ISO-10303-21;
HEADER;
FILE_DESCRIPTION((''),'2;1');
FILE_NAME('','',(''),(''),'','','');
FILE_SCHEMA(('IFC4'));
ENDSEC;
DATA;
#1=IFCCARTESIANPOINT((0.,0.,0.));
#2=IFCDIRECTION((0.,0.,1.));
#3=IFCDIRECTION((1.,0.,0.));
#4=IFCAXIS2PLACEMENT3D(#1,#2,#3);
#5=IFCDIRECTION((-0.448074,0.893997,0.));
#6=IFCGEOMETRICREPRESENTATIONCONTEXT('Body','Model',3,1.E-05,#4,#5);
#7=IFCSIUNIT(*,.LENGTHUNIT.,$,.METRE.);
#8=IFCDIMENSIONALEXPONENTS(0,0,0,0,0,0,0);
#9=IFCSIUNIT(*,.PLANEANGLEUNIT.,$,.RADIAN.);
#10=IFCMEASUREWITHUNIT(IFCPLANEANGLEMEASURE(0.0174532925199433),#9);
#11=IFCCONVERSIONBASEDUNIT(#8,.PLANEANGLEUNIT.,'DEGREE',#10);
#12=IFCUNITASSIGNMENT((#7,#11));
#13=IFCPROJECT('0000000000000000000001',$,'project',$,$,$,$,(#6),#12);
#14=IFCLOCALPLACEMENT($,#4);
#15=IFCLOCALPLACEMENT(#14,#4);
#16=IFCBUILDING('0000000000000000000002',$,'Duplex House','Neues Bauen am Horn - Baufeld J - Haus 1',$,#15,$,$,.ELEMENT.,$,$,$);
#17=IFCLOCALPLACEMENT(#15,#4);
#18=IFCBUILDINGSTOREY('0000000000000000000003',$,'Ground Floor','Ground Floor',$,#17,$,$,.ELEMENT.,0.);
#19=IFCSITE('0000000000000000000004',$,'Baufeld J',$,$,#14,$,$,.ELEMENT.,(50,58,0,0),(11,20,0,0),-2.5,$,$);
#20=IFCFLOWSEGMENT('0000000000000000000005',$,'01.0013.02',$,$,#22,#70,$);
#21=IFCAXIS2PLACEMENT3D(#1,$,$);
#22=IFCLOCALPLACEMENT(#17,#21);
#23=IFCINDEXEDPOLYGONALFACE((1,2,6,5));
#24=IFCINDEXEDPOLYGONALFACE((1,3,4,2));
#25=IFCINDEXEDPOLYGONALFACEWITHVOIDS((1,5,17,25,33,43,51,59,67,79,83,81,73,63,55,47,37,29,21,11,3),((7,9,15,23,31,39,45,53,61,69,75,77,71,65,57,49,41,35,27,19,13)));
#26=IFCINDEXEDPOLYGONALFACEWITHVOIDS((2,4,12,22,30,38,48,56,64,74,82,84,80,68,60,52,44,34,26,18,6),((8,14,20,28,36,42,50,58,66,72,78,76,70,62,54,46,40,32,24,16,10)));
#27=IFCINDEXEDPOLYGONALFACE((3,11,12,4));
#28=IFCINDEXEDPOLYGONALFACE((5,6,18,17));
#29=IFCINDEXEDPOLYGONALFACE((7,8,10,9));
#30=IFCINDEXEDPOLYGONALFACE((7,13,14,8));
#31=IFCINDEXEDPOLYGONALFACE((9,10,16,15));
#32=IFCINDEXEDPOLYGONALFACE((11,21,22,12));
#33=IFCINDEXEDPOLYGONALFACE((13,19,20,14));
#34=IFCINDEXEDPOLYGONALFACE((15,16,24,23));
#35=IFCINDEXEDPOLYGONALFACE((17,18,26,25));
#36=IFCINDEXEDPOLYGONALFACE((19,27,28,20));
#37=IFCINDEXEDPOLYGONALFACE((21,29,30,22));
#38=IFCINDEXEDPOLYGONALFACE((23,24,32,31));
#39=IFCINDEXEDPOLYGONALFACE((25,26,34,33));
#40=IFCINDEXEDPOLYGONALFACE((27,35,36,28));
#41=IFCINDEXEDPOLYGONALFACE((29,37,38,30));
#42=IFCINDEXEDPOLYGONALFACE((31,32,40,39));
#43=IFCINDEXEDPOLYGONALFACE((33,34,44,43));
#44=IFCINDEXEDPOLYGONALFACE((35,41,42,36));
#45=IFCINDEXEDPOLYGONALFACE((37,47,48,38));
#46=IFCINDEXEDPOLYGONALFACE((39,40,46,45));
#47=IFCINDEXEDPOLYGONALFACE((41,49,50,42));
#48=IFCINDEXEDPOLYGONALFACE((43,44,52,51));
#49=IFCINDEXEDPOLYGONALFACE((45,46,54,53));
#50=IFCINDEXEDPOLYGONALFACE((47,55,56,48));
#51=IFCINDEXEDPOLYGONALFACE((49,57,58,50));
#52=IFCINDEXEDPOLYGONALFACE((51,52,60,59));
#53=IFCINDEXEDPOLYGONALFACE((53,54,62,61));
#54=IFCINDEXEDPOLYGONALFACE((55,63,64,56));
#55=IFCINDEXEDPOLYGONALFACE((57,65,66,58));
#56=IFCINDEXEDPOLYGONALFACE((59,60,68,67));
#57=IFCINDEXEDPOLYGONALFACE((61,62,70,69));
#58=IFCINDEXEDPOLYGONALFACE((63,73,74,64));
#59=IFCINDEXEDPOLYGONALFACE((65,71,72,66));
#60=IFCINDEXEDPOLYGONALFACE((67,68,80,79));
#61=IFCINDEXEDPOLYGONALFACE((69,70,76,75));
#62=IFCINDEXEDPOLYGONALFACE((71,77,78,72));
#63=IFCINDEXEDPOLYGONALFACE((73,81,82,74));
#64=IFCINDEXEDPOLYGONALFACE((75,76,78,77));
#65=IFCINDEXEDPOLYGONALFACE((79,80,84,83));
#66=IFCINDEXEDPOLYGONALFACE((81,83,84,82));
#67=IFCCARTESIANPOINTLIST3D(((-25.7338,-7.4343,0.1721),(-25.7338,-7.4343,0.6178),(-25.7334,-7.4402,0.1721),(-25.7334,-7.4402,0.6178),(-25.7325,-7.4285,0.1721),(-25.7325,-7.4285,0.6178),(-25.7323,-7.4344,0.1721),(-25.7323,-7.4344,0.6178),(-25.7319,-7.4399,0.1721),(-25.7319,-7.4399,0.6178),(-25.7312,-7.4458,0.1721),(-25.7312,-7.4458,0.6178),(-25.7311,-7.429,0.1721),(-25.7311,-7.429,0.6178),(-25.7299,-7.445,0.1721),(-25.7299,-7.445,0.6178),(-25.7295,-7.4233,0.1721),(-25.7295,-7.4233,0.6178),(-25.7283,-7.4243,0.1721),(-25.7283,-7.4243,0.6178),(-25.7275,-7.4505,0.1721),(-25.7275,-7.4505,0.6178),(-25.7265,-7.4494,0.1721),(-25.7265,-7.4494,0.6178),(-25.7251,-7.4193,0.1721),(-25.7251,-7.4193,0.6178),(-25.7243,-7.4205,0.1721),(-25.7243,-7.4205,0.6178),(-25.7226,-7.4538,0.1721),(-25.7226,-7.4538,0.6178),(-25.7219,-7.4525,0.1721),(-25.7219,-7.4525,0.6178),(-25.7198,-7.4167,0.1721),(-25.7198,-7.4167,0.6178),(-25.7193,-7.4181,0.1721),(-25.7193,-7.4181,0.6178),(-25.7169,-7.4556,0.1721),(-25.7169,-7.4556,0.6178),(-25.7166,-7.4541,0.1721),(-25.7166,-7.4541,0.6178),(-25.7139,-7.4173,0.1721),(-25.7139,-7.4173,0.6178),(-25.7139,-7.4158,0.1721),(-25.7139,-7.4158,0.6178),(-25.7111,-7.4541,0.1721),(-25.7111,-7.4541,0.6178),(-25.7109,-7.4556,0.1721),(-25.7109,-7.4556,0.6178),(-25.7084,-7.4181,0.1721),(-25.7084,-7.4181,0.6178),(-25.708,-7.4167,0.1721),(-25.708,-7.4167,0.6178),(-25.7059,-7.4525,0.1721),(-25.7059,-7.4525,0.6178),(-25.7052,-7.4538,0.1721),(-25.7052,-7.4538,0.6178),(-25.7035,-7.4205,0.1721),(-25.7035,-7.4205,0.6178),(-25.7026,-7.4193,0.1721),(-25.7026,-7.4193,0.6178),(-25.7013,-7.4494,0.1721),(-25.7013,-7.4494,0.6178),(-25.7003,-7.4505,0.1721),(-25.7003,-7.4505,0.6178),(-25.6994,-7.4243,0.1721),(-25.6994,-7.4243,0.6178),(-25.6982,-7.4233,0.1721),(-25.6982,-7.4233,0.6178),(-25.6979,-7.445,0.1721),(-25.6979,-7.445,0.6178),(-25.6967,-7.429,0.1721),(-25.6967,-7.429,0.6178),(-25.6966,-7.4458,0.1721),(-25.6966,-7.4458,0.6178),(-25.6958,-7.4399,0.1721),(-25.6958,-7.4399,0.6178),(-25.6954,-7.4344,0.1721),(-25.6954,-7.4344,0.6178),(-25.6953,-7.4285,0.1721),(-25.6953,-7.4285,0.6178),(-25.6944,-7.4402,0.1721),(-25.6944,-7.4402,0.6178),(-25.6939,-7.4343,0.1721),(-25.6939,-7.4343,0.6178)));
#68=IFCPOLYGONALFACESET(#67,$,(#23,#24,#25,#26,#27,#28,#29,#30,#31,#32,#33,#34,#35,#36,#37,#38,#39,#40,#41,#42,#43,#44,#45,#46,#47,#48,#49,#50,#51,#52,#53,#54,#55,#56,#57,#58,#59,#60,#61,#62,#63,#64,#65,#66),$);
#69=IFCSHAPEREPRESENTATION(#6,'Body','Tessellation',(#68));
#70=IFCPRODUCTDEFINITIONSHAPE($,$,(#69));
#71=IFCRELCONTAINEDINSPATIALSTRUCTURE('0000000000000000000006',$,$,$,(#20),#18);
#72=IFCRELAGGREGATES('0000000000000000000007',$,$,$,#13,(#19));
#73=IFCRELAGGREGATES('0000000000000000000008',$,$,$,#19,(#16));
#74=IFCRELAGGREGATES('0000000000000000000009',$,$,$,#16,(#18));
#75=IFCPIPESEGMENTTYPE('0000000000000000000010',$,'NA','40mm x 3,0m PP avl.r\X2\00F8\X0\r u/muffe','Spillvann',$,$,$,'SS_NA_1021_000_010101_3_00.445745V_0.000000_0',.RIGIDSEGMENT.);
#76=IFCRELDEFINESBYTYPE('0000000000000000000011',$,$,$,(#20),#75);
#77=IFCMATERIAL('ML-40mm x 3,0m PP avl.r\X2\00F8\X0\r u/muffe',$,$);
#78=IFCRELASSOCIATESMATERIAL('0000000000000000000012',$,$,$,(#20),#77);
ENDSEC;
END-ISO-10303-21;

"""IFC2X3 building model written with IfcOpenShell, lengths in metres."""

from ifc_helpers import new_model, entity, si_unit, converted_unit, direction, frame, origin_with_axes, origin_2d_with_axis, place, context, project, spatial, hollow_circle, extrude, material, type_object, element, save


model = new_model("IFC2X3")

# Units and contexts
model_context = context("Model", 3, precision=1e-05, world=origin_with_axes(), true_north=direction((-0.448074, 0.893997, 0.0)), identifier="Body")
ifc_project = project(units=[si_unit("LENGTHUNIT", "METRE"), converted_unit("PLANEANGLEUNIT", "DEGREE", entity("IfcPlaneAngleMeasure", 0.0174532925199433), si_unit("PLANEANGLEUNIT", "RADIAN"), dimensions=[0, 0, 0, 0, 0, 0, 0])], contexts=[model_context])

# Site, building, storey
site_placement = place(None, origin_with_axes())
site = spatial("IfcSite", under=ifc_project, at=site_placement, Name="Baufeld J", CompositionType="ELEMENT", RefLatitude=(50, 58, 0, 0), RefLongitude=(11, 20, 0, 0), RefElevation=-2.5)
building_placement = place(site_placement, origin_with_axes())
building = spatial("IfcBuilding", under=site, at=building_placement, Name="Duplex House", Description="Neues Bauen am Horn - Baufeld J - Haus 1", CompositionType="ELEMENT")
storey_placement = place(building_placement, origin_with_axes())
storey = spatial("IfcBuildingStorey", under=building, at=storey_placement, Name="Ground Floor", Description="Ground Floor", CompositionType="ELEMENT", Elevation=0.0)

# Flow segment
ifc_material_1 = material(Name="ML-40mm x 3,0m PP avl.rør u/muffe")
pipe_segment_type_1 = type_object("IfcPipeSegmentType", Name="NA", Description="40mm x 3,0m PP avl.rør u/muffe", ApplicableOccurrence="Spillvann", ElementType="SS_NA_1021_000_010101_3_00.445745V_0.000000_0", PredefinedType="RIGIDSEGMENT")
flow_segment_1_placement = place(storey_placement, frame((-25.7139, -7.4358, 0.1721), z_axis=(0.0, -1.0, 0.0), x_axis=(0.0, 0.0, 1.0)))
element("IfcFlowSegment", 1, at=flow_segment_1_placement, inside=storey, type_object=pipe_segment_type_1, material=ifc_material_1, Name="01.0013.02", context=model_context, shape_type="SweptSolid", body=[
    extrude(hollow_circle(Radius=0.02, WallThickness=0.0015, at=origin_2d_with_axis()), frame((0.0, 0.0, 0.0), z_axis=(1.0, 0.0, 0.0), x_axis=(0.0, 0.0, -1.0)), (0.0, 0.0, 1.0), 0.4457),
])

save(model, "model.ifc")
